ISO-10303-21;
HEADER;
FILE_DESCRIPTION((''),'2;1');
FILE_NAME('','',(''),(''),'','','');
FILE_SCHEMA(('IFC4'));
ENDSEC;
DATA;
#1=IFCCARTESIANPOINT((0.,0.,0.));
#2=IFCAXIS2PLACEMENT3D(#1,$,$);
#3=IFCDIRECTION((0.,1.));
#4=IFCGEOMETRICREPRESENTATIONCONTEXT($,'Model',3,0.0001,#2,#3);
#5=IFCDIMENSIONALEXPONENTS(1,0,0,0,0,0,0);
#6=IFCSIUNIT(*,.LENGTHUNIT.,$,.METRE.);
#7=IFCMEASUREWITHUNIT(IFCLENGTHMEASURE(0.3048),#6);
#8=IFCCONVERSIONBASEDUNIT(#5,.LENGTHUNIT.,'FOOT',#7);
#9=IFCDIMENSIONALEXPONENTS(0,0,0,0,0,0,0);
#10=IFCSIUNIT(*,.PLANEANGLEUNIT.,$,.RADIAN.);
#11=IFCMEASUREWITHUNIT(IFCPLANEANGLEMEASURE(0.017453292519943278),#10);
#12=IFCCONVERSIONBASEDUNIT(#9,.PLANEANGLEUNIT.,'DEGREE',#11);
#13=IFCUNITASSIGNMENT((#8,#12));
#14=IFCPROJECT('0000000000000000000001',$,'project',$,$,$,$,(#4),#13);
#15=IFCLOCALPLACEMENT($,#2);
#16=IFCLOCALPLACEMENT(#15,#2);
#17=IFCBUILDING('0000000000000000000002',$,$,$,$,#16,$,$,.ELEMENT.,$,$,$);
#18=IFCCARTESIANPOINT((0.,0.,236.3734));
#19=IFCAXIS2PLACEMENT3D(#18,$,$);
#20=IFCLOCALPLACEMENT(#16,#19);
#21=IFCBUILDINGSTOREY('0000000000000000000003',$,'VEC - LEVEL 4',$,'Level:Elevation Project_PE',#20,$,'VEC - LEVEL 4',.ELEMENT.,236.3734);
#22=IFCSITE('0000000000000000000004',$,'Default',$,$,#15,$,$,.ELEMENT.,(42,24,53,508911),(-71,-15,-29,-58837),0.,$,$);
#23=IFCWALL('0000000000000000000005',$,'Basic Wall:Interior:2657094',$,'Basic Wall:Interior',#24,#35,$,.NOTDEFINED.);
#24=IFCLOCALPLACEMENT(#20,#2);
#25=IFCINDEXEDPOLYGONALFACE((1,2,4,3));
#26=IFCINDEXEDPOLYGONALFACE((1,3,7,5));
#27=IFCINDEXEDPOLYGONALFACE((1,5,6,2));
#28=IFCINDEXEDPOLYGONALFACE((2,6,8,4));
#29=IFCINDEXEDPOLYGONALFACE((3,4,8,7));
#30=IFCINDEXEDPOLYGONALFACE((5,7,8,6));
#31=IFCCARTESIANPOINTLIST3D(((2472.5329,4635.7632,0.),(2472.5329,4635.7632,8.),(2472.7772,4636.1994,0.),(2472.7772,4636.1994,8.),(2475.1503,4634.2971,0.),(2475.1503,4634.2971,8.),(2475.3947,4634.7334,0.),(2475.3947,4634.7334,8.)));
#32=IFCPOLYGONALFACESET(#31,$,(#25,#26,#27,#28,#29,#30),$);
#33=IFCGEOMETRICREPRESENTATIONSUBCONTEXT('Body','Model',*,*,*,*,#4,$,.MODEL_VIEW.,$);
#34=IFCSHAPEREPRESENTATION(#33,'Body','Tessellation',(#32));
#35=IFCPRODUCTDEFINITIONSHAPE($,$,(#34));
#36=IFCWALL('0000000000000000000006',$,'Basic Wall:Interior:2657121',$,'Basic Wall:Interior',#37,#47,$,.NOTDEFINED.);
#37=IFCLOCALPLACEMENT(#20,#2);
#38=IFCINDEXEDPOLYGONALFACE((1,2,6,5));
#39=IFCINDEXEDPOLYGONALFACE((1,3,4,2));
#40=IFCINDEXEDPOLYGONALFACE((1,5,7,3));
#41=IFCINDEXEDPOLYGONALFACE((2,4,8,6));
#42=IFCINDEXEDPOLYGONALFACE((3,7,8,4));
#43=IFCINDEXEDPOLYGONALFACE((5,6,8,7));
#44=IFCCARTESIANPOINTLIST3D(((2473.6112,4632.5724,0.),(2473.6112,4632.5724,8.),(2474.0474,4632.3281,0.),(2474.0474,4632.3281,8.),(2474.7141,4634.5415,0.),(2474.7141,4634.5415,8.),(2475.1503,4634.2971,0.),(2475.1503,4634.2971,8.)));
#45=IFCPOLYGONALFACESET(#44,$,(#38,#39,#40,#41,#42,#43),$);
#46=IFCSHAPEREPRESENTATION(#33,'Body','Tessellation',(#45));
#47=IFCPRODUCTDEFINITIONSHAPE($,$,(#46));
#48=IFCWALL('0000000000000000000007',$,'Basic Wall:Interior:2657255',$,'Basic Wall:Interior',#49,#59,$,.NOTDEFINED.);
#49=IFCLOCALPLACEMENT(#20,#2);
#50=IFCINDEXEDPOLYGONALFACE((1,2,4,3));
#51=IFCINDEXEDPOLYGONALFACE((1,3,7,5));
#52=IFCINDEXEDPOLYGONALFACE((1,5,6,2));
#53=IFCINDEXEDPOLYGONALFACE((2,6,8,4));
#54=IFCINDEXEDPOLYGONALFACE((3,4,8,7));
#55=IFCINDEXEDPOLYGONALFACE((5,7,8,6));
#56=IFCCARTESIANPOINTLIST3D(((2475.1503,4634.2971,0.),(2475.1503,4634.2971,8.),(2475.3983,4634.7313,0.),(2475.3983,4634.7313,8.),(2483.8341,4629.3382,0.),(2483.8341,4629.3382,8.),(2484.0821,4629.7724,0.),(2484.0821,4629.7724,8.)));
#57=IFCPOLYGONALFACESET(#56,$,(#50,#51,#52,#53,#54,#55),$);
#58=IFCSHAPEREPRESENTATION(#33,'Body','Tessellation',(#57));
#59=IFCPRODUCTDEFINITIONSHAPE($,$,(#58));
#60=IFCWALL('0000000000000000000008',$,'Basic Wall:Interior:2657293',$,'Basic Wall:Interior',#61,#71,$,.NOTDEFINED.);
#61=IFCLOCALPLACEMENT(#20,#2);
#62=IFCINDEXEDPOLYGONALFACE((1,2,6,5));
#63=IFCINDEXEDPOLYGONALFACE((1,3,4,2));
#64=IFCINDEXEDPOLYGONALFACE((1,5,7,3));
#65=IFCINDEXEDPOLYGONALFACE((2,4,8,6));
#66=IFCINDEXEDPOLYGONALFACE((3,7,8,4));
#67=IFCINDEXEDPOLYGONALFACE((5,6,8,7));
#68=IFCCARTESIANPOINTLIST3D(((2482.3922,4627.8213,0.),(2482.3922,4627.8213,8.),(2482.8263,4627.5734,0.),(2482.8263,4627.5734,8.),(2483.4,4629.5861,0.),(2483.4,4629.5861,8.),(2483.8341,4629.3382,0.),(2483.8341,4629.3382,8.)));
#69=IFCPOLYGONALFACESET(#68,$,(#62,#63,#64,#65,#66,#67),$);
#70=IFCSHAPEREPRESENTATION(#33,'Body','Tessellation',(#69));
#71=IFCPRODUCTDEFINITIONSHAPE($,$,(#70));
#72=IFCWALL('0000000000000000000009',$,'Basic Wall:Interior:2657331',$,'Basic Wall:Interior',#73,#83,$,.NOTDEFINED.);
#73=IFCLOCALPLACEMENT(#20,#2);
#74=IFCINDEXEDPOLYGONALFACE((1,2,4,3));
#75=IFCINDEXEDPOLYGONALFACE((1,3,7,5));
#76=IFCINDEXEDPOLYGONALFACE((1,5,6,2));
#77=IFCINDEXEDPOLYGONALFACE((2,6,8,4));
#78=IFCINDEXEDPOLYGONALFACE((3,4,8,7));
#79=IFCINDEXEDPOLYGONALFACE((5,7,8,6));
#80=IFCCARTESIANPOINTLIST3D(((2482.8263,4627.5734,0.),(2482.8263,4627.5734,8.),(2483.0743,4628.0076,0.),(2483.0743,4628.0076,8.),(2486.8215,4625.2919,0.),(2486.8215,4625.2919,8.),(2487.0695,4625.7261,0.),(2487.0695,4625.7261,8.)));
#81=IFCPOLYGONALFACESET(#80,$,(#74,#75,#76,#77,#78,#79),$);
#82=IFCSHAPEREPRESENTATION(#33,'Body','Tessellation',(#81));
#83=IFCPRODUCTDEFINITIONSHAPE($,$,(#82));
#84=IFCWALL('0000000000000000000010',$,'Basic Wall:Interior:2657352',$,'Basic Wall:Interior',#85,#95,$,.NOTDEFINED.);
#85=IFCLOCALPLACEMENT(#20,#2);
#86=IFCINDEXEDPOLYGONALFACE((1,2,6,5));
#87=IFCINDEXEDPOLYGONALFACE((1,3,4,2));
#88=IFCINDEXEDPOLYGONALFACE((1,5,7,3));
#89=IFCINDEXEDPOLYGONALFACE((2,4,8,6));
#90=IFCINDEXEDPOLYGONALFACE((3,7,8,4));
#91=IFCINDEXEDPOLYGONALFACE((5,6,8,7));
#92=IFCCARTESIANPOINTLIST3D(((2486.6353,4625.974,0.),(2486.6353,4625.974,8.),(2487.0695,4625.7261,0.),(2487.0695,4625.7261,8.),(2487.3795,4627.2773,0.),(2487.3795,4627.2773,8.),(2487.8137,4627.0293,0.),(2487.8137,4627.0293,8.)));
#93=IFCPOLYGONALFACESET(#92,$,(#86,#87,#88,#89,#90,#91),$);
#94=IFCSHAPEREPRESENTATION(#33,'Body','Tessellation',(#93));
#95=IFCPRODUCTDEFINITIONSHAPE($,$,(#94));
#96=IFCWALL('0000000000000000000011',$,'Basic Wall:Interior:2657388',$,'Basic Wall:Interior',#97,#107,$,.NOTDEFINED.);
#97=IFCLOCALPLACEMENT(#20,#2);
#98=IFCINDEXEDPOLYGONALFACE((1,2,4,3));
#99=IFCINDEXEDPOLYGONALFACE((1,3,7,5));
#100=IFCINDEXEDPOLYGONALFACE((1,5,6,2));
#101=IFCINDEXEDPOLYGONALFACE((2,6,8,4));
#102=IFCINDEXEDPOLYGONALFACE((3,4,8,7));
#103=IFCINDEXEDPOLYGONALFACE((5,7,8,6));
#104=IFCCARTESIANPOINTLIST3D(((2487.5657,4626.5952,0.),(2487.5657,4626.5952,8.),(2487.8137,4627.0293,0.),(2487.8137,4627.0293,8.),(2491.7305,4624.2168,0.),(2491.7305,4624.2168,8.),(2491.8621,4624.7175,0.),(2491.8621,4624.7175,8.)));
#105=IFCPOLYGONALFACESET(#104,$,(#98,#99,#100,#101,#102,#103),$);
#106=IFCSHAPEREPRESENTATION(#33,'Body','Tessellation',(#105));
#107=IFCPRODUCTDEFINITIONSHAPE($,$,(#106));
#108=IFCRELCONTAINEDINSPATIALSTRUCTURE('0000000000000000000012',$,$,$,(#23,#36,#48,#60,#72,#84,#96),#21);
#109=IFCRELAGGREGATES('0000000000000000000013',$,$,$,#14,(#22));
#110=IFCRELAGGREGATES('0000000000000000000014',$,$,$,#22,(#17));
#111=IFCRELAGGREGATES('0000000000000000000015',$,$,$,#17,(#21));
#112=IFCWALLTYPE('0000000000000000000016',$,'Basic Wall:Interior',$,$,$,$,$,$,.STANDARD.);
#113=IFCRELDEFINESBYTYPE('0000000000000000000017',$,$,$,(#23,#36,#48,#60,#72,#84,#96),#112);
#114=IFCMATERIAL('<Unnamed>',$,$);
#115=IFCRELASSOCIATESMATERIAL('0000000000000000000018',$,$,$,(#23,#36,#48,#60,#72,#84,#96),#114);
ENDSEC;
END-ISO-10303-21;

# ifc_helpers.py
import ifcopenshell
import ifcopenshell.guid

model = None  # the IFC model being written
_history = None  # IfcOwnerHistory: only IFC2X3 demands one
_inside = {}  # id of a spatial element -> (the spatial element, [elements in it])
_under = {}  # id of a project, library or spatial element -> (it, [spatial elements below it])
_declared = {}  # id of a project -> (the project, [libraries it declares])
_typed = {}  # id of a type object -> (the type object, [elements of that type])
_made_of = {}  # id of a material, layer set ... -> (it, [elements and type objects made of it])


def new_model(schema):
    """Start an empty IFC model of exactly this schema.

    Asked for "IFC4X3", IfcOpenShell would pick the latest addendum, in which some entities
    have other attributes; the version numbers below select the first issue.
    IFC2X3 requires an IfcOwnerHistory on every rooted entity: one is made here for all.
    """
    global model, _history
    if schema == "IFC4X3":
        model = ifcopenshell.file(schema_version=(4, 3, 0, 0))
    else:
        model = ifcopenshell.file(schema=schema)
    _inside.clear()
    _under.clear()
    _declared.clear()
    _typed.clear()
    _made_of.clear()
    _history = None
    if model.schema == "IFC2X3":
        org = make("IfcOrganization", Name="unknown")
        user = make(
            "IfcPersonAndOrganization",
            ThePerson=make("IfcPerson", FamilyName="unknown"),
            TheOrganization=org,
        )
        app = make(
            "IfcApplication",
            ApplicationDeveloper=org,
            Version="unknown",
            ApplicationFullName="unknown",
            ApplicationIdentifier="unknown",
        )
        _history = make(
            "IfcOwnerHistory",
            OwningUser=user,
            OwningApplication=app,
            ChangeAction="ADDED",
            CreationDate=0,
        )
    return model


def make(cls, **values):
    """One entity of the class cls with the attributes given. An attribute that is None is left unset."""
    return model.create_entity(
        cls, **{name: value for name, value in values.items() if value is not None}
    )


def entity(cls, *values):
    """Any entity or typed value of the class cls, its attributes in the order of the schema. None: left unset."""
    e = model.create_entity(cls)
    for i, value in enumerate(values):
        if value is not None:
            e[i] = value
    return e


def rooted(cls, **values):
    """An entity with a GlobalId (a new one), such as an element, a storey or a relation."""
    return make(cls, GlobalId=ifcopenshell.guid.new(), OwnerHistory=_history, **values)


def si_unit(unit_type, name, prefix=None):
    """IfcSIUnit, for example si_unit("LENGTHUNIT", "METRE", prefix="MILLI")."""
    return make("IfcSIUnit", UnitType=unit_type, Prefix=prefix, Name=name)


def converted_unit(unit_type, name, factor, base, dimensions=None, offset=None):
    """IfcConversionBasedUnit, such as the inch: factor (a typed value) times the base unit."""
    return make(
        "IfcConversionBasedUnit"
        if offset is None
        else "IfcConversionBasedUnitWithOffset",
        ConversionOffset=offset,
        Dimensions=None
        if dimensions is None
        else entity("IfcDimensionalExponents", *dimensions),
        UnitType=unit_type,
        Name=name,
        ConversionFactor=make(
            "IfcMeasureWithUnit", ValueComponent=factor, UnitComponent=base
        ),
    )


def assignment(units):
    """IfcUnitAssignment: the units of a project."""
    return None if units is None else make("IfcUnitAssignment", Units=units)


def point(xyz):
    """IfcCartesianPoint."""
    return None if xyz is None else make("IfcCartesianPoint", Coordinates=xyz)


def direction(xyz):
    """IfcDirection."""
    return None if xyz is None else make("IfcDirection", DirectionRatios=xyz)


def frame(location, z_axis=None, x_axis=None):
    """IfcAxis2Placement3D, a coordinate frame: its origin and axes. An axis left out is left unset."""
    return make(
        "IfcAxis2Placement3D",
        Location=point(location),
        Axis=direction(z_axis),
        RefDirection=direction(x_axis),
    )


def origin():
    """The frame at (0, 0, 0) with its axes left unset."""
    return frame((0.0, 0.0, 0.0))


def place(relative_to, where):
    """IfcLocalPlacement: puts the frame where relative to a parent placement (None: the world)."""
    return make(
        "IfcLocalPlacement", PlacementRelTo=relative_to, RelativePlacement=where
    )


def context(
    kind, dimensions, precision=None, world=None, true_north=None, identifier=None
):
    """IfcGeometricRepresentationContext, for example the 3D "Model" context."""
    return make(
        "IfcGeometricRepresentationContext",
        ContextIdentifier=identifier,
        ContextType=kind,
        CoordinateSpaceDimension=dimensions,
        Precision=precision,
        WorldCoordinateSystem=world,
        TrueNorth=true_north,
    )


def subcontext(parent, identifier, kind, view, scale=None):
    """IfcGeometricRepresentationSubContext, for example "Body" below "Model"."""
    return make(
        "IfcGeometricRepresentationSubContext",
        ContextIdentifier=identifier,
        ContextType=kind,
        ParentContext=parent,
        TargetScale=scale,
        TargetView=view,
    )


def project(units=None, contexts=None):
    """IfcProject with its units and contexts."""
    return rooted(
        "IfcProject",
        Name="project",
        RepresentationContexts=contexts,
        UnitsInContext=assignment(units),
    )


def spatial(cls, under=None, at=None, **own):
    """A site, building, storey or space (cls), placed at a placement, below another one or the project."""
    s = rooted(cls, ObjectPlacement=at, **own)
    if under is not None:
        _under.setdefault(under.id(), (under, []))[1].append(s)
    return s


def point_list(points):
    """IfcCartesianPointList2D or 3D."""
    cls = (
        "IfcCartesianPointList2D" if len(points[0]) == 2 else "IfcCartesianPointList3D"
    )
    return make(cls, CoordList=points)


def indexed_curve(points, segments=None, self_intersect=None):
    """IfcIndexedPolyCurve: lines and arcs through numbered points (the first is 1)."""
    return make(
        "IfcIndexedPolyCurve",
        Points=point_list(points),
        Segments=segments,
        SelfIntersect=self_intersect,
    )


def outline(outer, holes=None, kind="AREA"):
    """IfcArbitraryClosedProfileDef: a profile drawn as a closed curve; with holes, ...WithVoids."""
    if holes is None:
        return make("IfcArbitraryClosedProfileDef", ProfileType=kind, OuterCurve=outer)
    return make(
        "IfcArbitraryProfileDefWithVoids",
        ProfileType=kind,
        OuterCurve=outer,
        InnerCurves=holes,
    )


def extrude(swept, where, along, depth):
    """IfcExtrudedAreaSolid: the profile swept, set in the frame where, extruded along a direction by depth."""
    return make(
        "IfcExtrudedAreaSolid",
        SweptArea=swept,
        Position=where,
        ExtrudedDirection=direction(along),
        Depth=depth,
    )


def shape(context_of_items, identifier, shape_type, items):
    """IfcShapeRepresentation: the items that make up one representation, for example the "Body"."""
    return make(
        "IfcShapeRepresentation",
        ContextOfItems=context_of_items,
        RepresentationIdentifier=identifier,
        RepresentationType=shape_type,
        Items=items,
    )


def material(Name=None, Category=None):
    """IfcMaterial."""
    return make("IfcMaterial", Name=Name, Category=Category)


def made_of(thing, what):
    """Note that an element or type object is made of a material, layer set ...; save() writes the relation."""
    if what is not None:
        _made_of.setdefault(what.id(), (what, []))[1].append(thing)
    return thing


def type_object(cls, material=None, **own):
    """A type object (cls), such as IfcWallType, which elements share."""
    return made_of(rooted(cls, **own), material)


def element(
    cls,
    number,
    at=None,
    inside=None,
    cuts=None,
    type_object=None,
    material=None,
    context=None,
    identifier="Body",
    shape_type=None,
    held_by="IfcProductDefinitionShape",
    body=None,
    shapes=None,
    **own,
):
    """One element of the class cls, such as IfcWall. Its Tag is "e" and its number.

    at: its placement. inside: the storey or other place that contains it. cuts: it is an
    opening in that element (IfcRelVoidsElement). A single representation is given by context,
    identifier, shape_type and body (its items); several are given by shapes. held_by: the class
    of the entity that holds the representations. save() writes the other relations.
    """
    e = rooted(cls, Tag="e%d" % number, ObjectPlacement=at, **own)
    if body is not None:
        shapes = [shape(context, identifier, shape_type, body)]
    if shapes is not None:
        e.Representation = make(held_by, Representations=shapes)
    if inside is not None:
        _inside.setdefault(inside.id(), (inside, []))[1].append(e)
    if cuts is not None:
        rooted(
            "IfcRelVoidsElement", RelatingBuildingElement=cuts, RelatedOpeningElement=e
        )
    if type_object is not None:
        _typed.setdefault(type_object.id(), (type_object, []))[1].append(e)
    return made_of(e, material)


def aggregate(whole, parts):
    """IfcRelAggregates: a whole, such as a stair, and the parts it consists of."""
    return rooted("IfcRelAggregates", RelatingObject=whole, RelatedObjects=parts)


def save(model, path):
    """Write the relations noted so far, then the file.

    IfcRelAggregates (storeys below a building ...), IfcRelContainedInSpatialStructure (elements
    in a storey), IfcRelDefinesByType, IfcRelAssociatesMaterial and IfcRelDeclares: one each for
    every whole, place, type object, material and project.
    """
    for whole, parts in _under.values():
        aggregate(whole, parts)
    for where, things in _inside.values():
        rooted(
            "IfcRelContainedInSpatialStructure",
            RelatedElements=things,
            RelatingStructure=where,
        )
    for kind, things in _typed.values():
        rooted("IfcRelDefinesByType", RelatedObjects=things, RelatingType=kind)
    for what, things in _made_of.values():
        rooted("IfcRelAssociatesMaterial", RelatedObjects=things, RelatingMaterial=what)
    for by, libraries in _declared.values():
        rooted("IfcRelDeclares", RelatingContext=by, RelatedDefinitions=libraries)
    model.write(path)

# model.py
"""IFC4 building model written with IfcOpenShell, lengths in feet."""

from ifc_helpers import new_model, entity, si_unit, converted_unit, direction, frame, origin, place, context, subcontext, project, spatial, indexed_curve, outline, extrude, material, type_object, element, save


model = new_model("IFC4")

# Units and contexts
model_context = context("Model", 3, precision=0.0001, world=origin(), true_north=direction((0.0, 1.0)))
body_context = subcontext(model_context, "Body", "Model", "MODEL_VIEW")
ifc_project = project(units=[converted_unit("LENGTHUNIT", "FOOT", entity("IfcLengthMeasure", 0.3048), si_unit("LENGTHUNIT", "METRE"), dimensions=[1, 0, 0, 0, 0, 0, 0]), converted_unit("PLANEANGLEUNIT", "DEGREE", entity("IfcPlaneAngleMeasure", 0.017453292519943278), si_unit("PLANEANGLEUNIT", "RADIAN"), dimensions=[0, 0, 0, 0, 0, 0, 0])], contexts=[model_context])

# Site, building, storey
site_placement = place(None, origin())
site = spatial("IfcSite", under=ifc_project, at=site_placement, Name="Default", CompositionType="ELEMENT", RefLatitude=(42, 24, 53, 508911), RefLongitude=(-71, -15, -29, -58837), RefElevation=0.0)
building_placement = place(site_placement, origin())
building = spatial("IfcBuilding", under=site, at=building_placement, CompositionType="ELEMENT")
storey_placement = place(building_placement, frame((0.0, 0.0, 236.3734)))
storey = spatial("IfcBuildingStorey", under=building, at=storey_placement, Name="VEC - LEVEL 4", ObjectType="Level:Elevation Project_PE", LongName="VEC - LEVEL 4", CompositionType="ELEMENT", Elevation=236.3734)

# Walls
ifc_material_1 = material(Name="<Unnamed>")
wall_type = type_object("IfcWallType", Name="Basic Wall:Interior", PredefinedType="STANDARD")
wall_1_placement = place(storey_placement, frame((2472.655, 4635.9813, 0.0), z_axis=(0.0, 0.0, 1.0), x_axis=(0.872466, -0.488675, 0.0)))
element("IfcWall", 1, at=wall_1_placement, inside=storey, type_object=wall_type, material=ifc_material_1, Name="Basic Wall:Interior:2657094", ObjectType="Basic Wall:Interior", PredefinedType="NOTDEFINED", context=body_context, shape_type="SweptSolid", body=[
    extrude(outline(indexed_curve([(3.0001, 0.25), (0.0, 0.25), (0.0, -0.25), (3.0001, -0.25), (3.0001, 0.25)], self_intersect=False)), origin(), (0.0, 0.0, 1.0), 8.0),
])
wall_2_placement = place(storey_placement, frame((2474.9322, 4634.4193, 0.0), z_axis=(0.0, 0.0, 1.0), x_axis=(-0.488675, -0.872466, 0.0)))
element("IfcWall", 2, at=wall_2_placement, inside=storey, type_object=wall_type, material=ifc_material_1, Name="Basic Wall:Interior:2657121", ObjectType="Basic Wall:Interior", PredefinedType="NOTDEFINED", context=body_context, shape_type="SweptSolid", body=[
    extrude(outline(indexed_curve([(2.2569, 0.25), (0.0, 0.25), (0.0, -0.25), (2.2569, -0.25), (2.2569, 0.25)], self_intersect=False)), origin(), (0.0, 0.0, 1.0), 8.0),
])
wall_3_placement = place(storey_placement, frame((2475.2743, 4634.5142, 0.0), z_axis=(0.0, 0.0, 1.0), x_axis=(0.868382, -0.495895, 0.0)))
element("IfcWall", 3, at=wall_3_placement, inside=storey, type_object=wall_type, material=ifc_material_1, Name="Basic Wall:Interior:2657255", ObjectType="Basic Wall:Interior", PredefinedType="NOTDEFINED", context=body_context, shape_type="SweptSolid", body=[
    extrude(outline(indexed_curve([(10.0, 0.25), (0.0, 0.25), (0.0, -0.25), (10.0, -0.25), (10.0, 0.25)], self_intersect=False)), origin(), (0.0, 0.0, 1.0), 8.0),
])
wall_4_placement = place(storey_placement, frame((2483.617, 4629.4622, 0.0), z_axis=(0.0, 0.0, 1.0), x_axis=(-0.495895, -0.868382, 0.0)))
element("IfcWall", 4, at=wall_4_placement, inside=storey, type_object=wall_type, material=ifc_material_1, Name="Basic Wall:Interior:2657293", ObjectType="Basic Wall:Interior", PredefinedType="NOTDEFINED", context=body_context, shape_type="SweptSolid", body=[
    extrude(outline(indexed_curve([(2.0323, 0.25), (0.0, 0.25), (0.0, -0.25), (2.0323, -0.25), (2.0323, 0.25)], self_intersect=False)), origin(), (0.0, 0.0, 1.0), 8.0),
])
wall_5_placement = place(storey_placement, frame((2482.9503, 4627.7905, 0.0), z_axis=(0.0, 0.0, 1.0), x_axis=(0.868382, -0.495895, 0.0)))
element("IfcWall", 5, at=wall_5_placement, inside=storey, type_object=wall_type, material=ifc_material_1, Name="Basic Wall:Interior:2657331", ObjectType="Basic Wall:Interior", PredefinedType="NOTDEFINED", context=body_context, shape_type="SweptSolid", body=[
    extrude(outline(indexed_curve([(4.6007, 0.25), (0.0, 0.25), (0.0, -0.25), (4.6007, -0.25), (4.6007, 0.25)], self_intersect=False)), origin(), (0.0, 0.0, 1.0), 8.0),
])
wall_6_placement = place(storey_placement, frame((2486.8524, 4625.8501, 0.0), z_axis=(0.0, 0.0, 1.0), x_axis=(0.495895, 0.868382, 0.0)))
element("IfcWall", 6, at=wall_6_placement, inside=storey, type_object=wall_type, material=ifc_material_1, Name="Basic Wall:Interior:2657352", ObjectType="Basic Wall:Interior", PredefinedType="NOTDEFINED", context=body_context, shape_type="SweptSolid", body=[
    extrude(outline(indexed_curve([(1.5008, 0.25), (0.0, 0.25), (0.0, -0.25), (1.5008, -0.25), (1.5008, 0.25)], self_intersect=False)), origin(), (0.0, 0.0, 1.0), 8.0),
])
wall_7_placement = place(storey_placement, frame((2487.6897, 4626.8122, 0.0), z_axis=(0.0, 0.0, 1.0), x_axis=(0.868382, -0.495895, 0.0)))
element("IfcWall", 7, at=wall_7_placement, inside=storey, type_object=wall_type, material=ifc_material_1, Name="Basic Wall:Interior:2657388", ObjectType="Basic Wall:Interior", PredefinedType="NOTDEFINED", context=body_context, shape_type="SweptSolid", body=[
    extrude(outline(indexed_curve([(4.796, -0.25), (4.662, 0.25), (0.0, 0.25), (0.0, -0.25), (4.796, -0.25)], self_intersect=False)), origin(), (0.0, 0.0, 1.0), 8.0),
])

save(model, "model.ifc")
